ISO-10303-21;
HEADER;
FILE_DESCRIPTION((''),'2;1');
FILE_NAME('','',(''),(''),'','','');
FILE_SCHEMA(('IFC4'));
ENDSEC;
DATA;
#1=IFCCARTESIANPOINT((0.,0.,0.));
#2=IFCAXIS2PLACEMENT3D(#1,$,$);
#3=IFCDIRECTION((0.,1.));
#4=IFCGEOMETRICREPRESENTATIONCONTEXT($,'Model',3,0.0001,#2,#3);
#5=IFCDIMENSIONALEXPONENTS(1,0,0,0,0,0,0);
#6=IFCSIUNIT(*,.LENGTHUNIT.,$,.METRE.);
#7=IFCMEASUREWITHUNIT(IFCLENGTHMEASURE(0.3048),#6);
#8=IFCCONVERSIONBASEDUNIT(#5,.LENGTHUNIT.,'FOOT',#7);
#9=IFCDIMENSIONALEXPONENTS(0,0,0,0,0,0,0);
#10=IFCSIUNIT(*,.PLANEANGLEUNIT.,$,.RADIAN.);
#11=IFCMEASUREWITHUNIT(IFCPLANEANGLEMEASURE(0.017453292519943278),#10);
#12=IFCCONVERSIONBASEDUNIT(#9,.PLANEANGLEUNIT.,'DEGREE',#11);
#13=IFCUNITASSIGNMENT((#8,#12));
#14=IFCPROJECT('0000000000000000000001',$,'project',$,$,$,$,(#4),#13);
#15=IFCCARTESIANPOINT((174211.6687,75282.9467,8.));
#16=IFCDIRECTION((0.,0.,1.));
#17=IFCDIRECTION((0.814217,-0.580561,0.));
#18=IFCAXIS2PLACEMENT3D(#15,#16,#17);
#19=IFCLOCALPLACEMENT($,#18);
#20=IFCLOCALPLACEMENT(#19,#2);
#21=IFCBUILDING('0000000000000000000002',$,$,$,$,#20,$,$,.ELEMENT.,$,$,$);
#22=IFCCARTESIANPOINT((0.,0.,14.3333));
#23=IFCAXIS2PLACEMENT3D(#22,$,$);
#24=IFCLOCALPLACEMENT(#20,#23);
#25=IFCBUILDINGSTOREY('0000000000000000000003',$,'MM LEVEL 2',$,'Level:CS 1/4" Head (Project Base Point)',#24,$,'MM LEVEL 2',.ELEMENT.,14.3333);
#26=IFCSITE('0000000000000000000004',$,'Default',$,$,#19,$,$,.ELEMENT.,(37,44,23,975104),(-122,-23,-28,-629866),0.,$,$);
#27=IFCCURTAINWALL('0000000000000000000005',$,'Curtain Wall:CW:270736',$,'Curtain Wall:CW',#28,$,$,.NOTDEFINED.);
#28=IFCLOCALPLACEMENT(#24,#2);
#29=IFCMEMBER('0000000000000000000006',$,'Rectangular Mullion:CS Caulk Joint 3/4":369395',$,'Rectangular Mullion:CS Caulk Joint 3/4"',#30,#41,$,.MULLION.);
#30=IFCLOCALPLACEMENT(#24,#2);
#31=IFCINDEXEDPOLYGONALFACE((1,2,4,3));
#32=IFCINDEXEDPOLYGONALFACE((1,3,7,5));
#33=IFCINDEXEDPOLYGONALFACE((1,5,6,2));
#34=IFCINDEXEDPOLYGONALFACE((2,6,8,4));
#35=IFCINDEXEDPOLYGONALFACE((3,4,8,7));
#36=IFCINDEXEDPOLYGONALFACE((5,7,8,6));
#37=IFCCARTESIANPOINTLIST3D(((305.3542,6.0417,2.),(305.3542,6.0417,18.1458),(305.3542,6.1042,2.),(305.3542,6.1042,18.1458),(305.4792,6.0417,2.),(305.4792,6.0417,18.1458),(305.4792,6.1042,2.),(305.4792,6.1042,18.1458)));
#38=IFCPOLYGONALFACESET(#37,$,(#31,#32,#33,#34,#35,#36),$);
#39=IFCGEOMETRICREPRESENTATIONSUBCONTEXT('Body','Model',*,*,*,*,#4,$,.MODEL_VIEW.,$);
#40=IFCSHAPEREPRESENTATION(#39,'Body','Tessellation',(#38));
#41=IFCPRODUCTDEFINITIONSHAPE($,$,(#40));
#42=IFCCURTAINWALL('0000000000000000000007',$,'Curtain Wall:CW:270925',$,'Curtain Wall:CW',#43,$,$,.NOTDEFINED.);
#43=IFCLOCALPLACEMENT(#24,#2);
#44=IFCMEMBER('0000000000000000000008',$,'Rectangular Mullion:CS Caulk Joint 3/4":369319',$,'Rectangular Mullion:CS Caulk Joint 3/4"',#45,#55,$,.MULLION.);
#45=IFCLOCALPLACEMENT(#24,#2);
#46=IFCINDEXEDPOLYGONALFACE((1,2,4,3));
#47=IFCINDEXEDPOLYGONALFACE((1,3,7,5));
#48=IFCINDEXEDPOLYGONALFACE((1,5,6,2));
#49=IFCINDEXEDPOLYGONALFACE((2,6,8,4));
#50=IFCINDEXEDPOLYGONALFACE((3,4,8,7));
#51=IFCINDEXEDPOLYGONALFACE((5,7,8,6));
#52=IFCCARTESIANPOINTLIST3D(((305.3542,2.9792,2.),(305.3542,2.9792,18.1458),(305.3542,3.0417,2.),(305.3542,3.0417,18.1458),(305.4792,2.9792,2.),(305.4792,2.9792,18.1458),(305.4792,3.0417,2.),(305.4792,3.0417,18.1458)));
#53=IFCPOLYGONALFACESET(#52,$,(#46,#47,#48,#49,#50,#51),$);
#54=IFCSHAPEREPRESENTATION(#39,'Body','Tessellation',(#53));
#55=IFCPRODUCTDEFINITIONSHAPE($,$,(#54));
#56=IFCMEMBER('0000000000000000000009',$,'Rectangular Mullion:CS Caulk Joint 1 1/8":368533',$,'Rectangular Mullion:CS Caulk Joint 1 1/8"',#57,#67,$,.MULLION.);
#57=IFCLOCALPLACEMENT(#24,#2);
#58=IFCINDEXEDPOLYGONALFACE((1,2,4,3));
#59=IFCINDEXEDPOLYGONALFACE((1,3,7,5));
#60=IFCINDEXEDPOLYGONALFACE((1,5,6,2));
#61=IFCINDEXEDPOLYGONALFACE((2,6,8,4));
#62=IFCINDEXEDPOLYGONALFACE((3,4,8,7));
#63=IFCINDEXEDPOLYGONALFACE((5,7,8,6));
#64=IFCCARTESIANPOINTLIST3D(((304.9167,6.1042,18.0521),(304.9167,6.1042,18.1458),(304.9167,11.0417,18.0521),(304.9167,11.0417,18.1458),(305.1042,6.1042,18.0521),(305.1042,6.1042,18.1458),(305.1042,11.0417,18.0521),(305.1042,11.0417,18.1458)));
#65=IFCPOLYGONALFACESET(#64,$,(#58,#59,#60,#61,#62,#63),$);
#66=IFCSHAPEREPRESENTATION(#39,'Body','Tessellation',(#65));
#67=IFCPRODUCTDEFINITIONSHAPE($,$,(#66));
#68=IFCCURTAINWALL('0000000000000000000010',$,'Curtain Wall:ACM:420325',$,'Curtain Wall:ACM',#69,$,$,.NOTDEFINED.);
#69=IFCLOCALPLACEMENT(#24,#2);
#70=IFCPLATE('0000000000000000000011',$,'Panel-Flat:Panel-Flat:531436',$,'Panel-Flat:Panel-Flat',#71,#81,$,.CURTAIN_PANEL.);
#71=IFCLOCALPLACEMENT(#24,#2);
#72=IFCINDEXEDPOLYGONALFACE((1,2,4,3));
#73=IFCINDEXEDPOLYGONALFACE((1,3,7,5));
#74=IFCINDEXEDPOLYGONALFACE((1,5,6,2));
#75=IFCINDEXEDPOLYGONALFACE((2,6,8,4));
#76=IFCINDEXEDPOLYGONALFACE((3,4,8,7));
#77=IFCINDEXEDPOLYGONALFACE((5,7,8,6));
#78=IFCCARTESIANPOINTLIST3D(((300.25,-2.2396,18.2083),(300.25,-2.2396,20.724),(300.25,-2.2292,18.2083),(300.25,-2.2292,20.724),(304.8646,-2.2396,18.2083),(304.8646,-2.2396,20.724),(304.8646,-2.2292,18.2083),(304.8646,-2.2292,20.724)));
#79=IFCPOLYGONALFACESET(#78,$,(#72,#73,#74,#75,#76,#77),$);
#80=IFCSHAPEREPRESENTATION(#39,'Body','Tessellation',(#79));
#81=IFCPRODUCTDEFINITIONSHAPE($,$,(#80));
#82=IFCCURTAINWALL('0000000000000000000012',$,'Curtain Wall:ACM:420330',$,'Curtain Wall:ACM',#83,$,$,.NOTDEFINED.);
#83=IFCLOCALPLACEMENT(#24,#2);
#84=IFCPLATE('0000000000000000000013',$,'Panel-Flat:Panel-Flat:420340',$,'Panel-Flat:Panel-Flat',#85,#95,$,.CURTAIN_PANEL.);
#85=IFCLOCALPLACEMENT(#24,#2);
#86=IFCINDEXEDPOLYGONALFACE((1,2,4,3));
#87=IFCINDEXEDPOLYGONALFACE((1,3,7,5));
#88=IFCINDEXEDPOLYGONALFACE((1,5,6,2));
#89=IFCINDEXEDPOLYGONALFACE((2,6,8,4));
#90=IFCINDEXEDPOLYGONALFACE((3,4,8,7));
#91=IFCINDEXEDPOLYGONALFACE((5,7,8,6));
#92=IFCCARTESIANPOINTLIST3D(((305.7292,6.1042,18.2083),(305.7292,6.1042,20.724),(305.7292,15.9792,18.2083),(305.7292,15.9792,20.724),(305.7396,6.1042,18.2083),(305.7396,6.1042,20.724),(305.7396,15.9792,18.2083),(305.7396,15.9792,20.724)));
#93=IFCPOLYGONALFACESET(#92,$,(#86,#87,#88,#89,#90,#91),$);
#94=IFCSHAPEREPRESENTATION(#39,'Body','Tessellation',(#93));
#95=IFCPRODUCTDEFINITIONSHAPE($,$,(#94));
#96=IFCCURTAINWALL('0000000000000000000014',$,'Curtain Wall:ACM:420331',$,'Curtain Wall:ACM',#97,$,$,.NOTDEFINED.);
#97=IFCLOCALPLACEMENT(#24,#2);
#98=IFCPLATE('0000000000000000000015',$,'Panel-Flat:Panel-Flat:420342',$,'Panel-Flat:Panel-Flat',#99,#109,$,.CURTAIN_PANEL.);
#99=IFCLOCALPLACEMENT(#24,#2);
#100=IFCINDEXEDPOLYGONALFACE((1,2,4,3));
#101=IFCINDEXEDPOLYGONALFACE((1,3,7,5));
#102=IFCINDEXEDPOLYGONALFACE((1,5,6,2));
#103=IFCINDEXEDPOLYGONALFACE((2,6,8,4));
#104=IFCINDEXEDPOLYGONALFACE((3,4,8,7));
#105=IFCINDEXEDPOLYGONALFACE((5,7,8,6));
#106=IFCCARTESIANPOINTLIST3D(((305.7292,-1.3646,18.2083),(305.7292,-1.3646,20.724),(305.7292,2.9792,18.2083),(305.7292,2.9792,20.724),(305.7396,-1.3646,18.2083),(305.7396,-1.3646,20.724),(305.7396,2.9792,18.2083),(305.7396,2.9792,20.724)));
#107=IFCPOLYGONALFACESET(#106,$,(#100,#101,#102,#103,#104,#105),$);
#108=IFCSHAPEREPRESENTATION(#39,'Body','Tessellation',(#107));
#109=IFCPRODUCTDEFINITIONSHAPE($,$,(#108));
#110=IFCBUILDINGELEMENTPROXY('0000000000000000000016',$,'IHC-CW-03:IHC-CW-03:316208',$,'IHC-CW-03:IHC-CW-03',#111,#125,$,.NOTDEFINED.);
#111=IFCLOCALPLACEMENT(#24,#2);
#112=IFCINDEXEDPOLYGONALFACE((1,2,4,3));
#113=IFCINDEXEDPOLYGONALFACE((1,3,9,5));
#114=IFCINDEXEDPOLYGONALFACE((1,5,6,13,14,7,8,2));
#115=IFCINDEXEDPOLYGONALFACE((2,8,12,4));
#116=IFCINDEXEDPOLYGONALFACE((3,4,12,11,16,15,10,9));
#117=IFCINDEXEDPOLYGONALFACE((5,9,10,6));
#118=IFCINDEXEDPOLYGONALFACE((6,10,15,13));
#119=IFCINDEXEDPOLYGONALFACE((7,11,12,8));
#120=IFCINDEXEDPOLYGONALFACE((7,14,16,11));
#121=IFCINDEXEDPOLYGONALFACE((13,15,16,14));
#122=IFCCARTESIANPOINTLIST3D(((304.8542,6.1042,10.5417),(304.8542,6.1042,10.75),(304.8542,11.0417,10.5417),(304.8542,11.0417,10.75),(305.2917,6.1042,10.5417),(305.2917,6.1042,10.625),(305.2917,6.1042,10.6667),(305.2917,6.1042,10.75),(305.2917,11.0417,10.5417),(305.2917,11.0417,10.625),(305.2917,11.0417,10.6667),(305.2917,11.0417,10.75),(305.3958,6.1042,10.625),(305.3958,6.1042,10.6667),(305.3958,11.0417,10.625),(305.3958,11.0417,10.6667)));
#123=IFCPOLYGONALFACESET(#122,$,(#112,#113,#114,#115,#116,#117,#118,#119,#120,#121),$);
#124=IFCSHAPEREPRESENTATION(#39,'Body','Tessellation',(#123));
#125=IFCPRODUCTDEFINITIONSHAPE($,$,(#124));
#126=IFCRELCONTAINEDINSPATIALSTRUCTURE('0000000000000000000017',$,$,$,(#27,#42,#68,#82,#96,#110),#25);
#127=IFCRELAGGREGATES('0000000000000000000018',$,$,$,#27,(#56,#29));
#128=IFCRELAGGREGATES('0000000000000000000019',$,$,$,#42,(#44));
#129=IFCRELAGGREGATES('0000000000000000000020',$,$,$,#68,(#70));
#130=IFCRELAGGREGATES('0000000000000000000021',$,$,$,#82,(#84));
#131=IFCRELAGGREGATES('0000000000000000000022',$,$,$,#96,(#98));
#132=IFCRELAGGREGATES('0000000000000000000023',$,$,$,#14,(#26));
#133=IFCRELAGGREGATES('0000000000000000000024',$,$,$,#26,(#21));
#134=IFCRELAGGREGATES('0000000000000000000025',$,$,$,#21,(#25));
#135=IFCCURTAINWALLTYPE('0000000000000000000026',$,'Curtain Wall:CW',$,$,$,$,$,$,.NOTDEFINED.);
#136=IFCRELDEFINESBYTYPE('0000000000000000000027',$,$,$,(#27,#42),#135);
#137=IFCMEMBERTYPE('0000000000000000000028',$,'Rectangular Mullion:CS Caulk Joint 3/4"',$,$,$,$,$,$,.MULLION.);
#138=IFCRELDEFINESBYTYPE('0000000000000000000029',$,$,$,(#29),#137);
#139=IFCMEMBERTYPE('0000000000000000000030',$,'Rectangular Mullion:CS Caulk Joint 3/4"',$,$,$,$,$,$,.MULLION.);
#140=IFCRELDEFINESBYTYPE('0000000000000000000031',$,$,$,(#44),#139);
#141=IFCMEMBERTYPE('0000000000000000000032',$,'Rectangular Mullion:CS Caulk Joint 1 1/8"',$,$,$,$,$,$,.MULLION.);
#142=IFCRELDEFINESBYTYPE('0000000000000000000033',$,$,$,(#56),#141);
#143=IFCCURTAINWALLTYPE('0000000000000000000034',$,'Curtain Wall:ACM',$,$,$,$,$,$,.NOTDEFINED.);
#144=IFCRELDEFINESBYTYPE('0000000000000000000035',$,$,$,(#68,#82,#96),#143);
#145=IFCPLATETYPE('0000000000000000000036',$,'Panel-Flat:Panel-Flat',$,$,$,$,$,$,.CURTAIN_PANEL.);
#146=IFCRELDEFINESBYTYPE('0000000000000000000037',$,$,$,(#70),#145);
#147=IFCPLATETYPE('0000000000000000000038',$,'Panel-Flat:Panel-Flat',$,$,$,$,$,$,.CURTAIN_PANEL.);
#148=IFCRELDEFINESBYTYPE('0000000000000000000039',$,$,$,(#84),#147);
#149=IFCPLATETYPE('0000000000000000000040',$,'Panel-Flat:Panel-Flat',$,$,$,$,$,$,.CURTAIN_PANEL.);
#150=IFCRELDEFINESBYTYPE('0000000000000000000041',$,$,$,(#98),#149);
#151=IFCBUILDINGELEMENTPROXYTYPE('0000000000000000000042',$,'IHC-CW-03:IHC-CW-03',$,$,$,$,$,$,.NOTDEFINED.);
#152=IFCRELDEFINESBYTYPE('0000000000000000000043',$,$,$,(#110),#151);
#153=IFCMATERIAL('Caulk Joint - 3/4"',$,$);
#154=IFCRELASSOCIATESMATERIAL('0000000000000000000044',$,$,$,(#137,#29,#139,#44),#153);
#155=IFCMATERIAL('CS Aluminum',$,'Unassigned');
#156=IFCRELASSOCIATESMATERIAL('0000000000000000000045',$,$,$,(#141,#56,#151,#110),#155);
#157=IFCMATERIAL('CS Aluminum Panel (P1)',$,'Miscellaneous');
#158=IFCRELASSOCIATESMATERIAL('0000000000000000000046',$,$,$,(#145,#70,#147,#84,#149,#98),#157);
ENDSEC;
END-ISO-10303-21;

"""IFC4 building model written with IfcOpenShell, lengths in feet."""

from ifc_helpers import new_model, entity, si_unit, converted_unit, direction, frame, origin, place, context, subcontext, project, spatial, indexed_curve, outline, extrude, source, transform, mapped, material, type_object, type_shapes, element, aggregate, save


model = new_model("IFC4")

# Units and contexts
model_context = context("Model", 3, precision=0.0001, world=origin(), true_north=direction((0.0, 1.0)))
body_context = subcontext(model_context, "Body", "Model", "MODEL_VIEW")
ifc_project = project(units=[converted_unit("LENGTHUNIT", "FOOT", entity("IfcLengthMeasure", 0.3048), si_unit("LENGTHUNIT", "METRE"), dimensions=[1, 0, 0, 0, 0, 0, 0]), converted_unit("PLANEANGLEUNIT", "DEGREE", entity("IfcPlaneAngleMeasure", 0.017453292519943278), si_unit("PLANEANGLEUNIT", "RADIAN"), dimensions=[0, 0, 0, 0, 0, 0, 0])], contexts=[model_context])

# Site, building, storey
site_placement = place(None, frame((174211.6687, 75282.9467, 8.0), z_axis=(0.0, 0.0, 1.0), x_axis=(0.814217, -0.580561, 0.0)))
site = spatial("IfcSite", under=ifc_project, at=site_placement, Name="Default", CompositionType="ELEMENT", RefLatitude=(37, 44, 23, 975104), RefLongitude=(-122, -23, -28, -629866), RefElevation=0.0)
building_placement = place(site_placement, origin())
building = spatial("IfcBuilding", under=site, at=building_placement, CompositionType="ELEMENT")
storey_placement = place(building_placement, frame((0.0, 0.0, 14.3333)))
storey = spatial("IfcBuildingStorey", under=building, at=storey_placement, Name="MM LEVEL 2", ObjectType="Level:CS 1/4\" Head (Project Base Point)", LongName="MM LEVEL 2", CompositionType="ELEMENT", Elevation=14.3333)

# Curtain walls, members
curtain_wall_type_1 = type_object("IfcCurtainWallType", Name="Curtain Wall:CW", PredefinedType="NOTDEFINED")
curtain_wall_1_placement = place(storey_placement, frame((0.0, 0.0, -14.3333)))
curtain_wall_1 = element("IfcCurtainWall", 1, at=curtain_wall_1_placement, inside=storey, type_object=curtain_wall_type_1, Name="Curtain Wall:CW:270736", ObjectType="Curtain Wall:CW", PredefinedType="NOTDEFINED")
ifc_material_1 = material(Name="Caulk Joint - 3/4\"")
member_type_1 = type_object("IfcMemberType", Name="Rectangular Mullion:CS Caulk Joint 3/4\"", PredefinedType="MULLION", material=ifc_material_1)
shared_shape_1 = source(origin(), body_context, "Body", "SweptSolid", [
    extrude(outline(indexed_curve([(-0.0625, -0.0312), (0.0625, -0.0312), (0.0625, 0.0312), (-0.0625, 0.0312), (-0.0625, -0.0312)], self_intersect=False)), frame((-0.0312, 0.0625, -16.1458), z_axis=(0.0, 0.0, 1.0), x_axis=(0.0, -1.0, 0.0)), (0.0, 0.0, 1.0), 16.1458),
])
type_shapes(member_type_1, [shared_shape_1])
member_1_placement = place(curtain_wall_1_placement, frame((305.4792, 6.0417, 16.3333), z_axis=(0.0, 0.0, -1.0), x_axis=(0.0, -1.0, 0.0)))
member_1 = element("IfcMember", 2, at=member_1_placement, type_object=member_type_1, material=ifc_material_1, Name="Rectangular Mullion:CS Caulk Joint 3/4\":369395", ObjectType="Rectangular Mullion:CS Caulk Joint 3/4\"", PredefinedType="MULLION", context=body_context, shape_type="MappedRepresentation", body=[
    mapped(shared_shape_1, transform((0.0, 0.0, 0.0), scale=1.0)),
])
curtain_wall_2_placement = place(storey_placement, frame((0.0, 0.0, -14.3333)))
curtain_wall_2 = element("IfcCurtainWall", 3, at=curtain_wall_2_placement, inside=storey, type_object=curtain_wall_type_1, Name="Curtain Wall:CW:270925", ObjectType="Curtain Wall:CW", PredefinedType="NOTDEFINED")
member_type_2 = type_object("IfcMemberType", Name="Rectangular Mullion:CS Caulk Joint 3/4\"", PredefinedType="MULLION", material=ifc_material_1)
shared_shape_2 = source(origin(), body_context, "Body", "SweptSolid", [
    extrude(outline(indexed_curve([(-0.0312, -0.0625), (0.0312, -0.0625), (0.0312, 0.0625), (-0.0312, 0.0625), (-0.0312, -0.0625)], self_intersect=False)), frame((-0.0312, 0.0625, -16.1458), z_axis=(0.0, 0.0, 1.0), x_axis=(-1.0, 0.0, 0.0)), (0.0, 0.0, 1.0), 16.1458),
])
type_shapes(member_type_2, [shared_shape_2])
member_2_placement = place(curtain_wall_2_placement, frame((305.4792, 3.0417, 32.4792), z_axis=(0.0, 0.0, 1.0), x_axis=(0.0, 1.0, 0.0)))
member_2 = element("IfcMember", 4, at=member_2_placement, type_object=member_type_2, material=ifc_material_1, Name="Rectangular Mullion:CS Caulk Joint 3/4\":369319", ObjectType="Rectangular Mullion:CS Caulk Joint 3/4\"", PredefinedType="MULLION", context=body_context, shape_type="MappedRepresentation", body=[
    mapped(shared_shape_2, transform((0.0, 0.0, 0.0), scale=1.0)),
])

# Member
ifc_material_2 = material(Name="CS Aluminum", Category="Unassigned")
member_type_3 = type_object("IfcMemberType", Name="Rectangular Mullion:CS Caulk Joint 1 1/8\"", PredefinedType="MULLION", material=ifc_material_2)
shared_shape_3 = source(origin(), body_context, "Body", "SweptSolid", [
    extrude(outline(indexed_curve([(-0.0937, -0.0469), (0.0938, -0.0469), (0.0938, 0.0469), (-0.0937, 0.0469), (-0.0937, -0.0469)], self_intersect=False)), frame((-0.0469, 0.4688, -4.9375), z_axis=(0.0, 0.0, 1.0), x_axis=(0.0, -1.0, 0.0)), (0.0, 0.0, 1.0), 4.9375),
])
type_shapes(member_type_3, [shared_shape_3])
member_3_placement = place(curtain_wall_1_placement, frame((305.4792, 6.1042, 32.4792), z_axis=(0.0, -1.0, 0.0), x_axis=(0.0, 0.0, 1.0)))
member_3 = element("IfcMember", 5, at=member_3_placement, type_object=member_type_3, material=ifc_material_2, Name="Rectangular Mullion:CS Caulk Joint 1 1/8\":368533", ObjectType="Rectangular Mullion:CS Caulk Joint 1 1/8\"", PredefinedType="MULLION", context=body_context, shape_type="MappedRepresentation", body=[
    mapped(shared_shape_3, transform((0.0, 0.0, 0.0), scale=1.0)),
])
aggregate(curtain_wall_1, [member_3, member_1])
aggregate(curtain_wall_2, [member_2])

# Curtain walls, plates
curtain_wall_type_2 = type_object("IfcCurtainWallType", Name="Curtain Wall:ACM", PredefinedType="NOTDEFINED")
curtain_wall_3_placement = place(storey_placement, frame((0.0, 0.0, -14.3333)))
curtain_wall_3 = element("IfcCurtainWall", 6, at=curtain_wall_3_placement, inside=storey, type_object=curtain_wall_type_2, Name="Curtain Wall:ACM:420325", ObjectType="Curtain Wall:ACM", PredefinedType="NOTDEFINED")
ifc_material_3 = material(Name="CS Aluminum Panel (P1)", Category="Miscellaneous")
plate_type_1 = type_object("IfcPlateType", Name="Panel-Flat:Panel-Flat", PredefinedType="CURTAIN_PANEL", material=ifc_material_3)
shared_shape_4 = source(origin(), body_context, "Body", "SweptSolid", [
    extrude(outline(indexed_curve([(-0.0052, -2.3073), (0.0052, -2.3073), (0.0052, 2.3073), (-0.0052, 2.3073), (-0.0052, -2.3073)], self_intersect=False)), frame((-0.0208, -0.0052, 0.0), z_axis=(0.0, 0.0, 1.0), x_axis=(0.0, -1.0, 0.0)), (0.0, 0.0, 1.0), 2.5156),
])
type_shapes(plate_type_1, [shared_shape_4])
plate_1_placement = place(curtain_wall_3_placement, frame((302.5365, -2.2396, 32.5417), z_axis=(0.0, 0.0, 1.0), x_axis=(-1.0, 0.0, 0.0)))
plate_1 = element("IfcPlate", 7, at=plate_1_placement, type_object=plate_type_1, material=ifc_material_3, Name="Panel-Flat:Panel-Flat:531436", ObjectType="Panel-Flat:Panel-Flat", PredefinedType="CURTAIN_PANEL", context=body_context, shape_type="MappedRepresentation", body=[
    mapped(shared_shape_4, transform((0.0, 0.0, 0.0), scale=1.0)),
])
aggregate(curtain_wall_3, [plate_1])
curtain_wall_4_placement = place(storey_placement, frame((0.0, 0.0, -14.3333)))
curtain_wall_4 = element("IfcCurtainWall", 8, at=curtain_wall_4_placement, inside=storey, type_object=curtain_wall_type_2, Name="Curtain Wall:ACM:420330", ObjectType="Curtain Wall:ACM", PredefinedType="NOTDEFINED")
plate_type_2 = type_object("IfcPlateType", Name="Panel-Flat:Panel-Flat", PredefinedType="CURTAIN_PANEL", material=ifc_material_3)
shared_shape_5 = source(origin(), body_context, "Body", "SweptSolid", [
    extrude(outline(indexed_curve([(-0.0052, -4.9375), (0.0052, -4.9375), (0.0052, 4.9375), (-0.0052, 4.9375), (-0.0052, -4.9375)], self_intersect=False)), frame((0.0, -0.0052, 0.0), z_axis=(0.0, 0.0, 1.0), x_axis=(0.0, -1.0, 0.0)), (0.0, 0.0, 1.0), 2.5156),
])
type_shapes(plate_type_2, [shared_shape_5])
plate_2_placement = place(curtain_wall_4_placement, frame((305.7396, 11.0417, 32.5417), z_axis=(0.0, 0.0, 1.0), x_axis=(0.0, -1.0, 0.0)))
plate_2 = element("IfcPlate", 9, at=plate_2_placement, type_object=plate_type_2, material=ifc_material_3, Name="Panel-Flat:Panel-Flat:420340", ObjectType="Panel-Flat:Panel-Flat", PredefinedType="CURTAIN_PANEL", context=body_context, shape_type="MappedRepresentation", body=[
    mapped(shared_shape_5, transform((0.0, 0.0, 0.0), scale=1.0)),
])
aggregate(curtain_wall_4, [plate_2])

# Curtain wall, plate
curtain_wall_5_placement = place(storey_placement, frame((0.0, 0.0, -14.3333)))
curtain_wall_5 = element("IfcCurtainWall", 10, at=curtain_wall_5_placement, inside=storey, type_object=curtain_wall_type_2, Name="Curtain Wall:ACM:420331", ObjectType="Curtain Wall:ACM", PredefinedType="NOTDEFINED")
plate_type_3 = type_object("IfcPlateType", Name="Panel-Flat:Panel-Flat", PredefinedType="CURTAIN_PANEL", material=ifc_material_3)
shared_shape_6 = source(origin(), body_context, "Body", "SweptSolid", [
    extrude(outline(indexed_curve([(-0.0052, -2.1719), (0.0052, -2.1719), (0.0052, 2.1719), (-0.0052, 2.1719), (-0.0052, -2.1719)], self_intersect=False)), frame((0.0208, -0.0052, 0.0), z_axis=(0.0, 0.0, 1.0), x_axis=(0.0, -1.0, 0.0)), (0.0, 0.0, 1.0), 2.5156),
])
type_shapes(plate_type_3, [shared_shape_6])
plate_3_placement = place(curtain_wall_5_placement, frame((305.7396, 0.8281, 32.5417), z_axis=(0.0, 0.0, 1.0), x_axis=(0.0, -1.0, 0.0)))
plate_3 = element("IfcPlate", 11, at=plate_3_placement, type_object=plate_type_3, material=ifc_material_3, Name="Panel-Flat:Panel-Flat:420342", ObjectType="Panel-Flat:Panel-Flat", PredefinedType="CURTAIN_PANEL", context=body_context, shape_type="MappedRepresentation", body=[
    mapped(shared_shape_6, transform((0.0, 0.0, 0.0), scale=1.0)),
])
aggregate(curtain_wall_5, [plate_3])

# Building element proxy
building_element_proxy_type_1 = type_object("IfcBuildingElementProxyType", Name="IHC-CW-03:IHC-CW-03", PredefinedType="NOTDEFINED", material=ifc_material_2)
shared_shape_7 = source(origin(), body_context, "Body", "SweptSolid", [
    extrude(outline(indexed_curve([(-0.0208, -0.1875), (0.0208, -0.1875), (0.0208, -0.0833), (0.1042, -0.0833), (0.1042, 0.3542), (-0.1042, 0.3542), (-0.1042, -0.0833), (-0.0208, -0.0833), (-0.0208, -0.1875)], self_intersect=False)), frame((-2.4688, -0.2708, -0.1042), z_axis=(1.0, 0.0, 0.0), x_axis=(0.0, 0.0, 1.0)), (0.0, 0.0, 1.0), 4.9375),
])
type_shapes(building_element_proxy_type_1, [shared_shape_7])
proxy_1_placement = place(storey_placement, frame((305.4792, 8.5729, 10.75), z_axis=(0.0, 0.0, 1.0), x_axis=(0.0, -1.0, 0.0)))
element("IfcBuildingElementProxy", 12, at=proxy_1_placement, inside=storey, type_object=building_element_proxy_type_1, material=ifc_material_2, Name="IHC-CW-03:IHC-CW-03:316208", ObjectType="IHC-CW-03:IHC-CW-03", PredefinedType="NOTDEFINED", context=body_context, shape_type="MappedRepresentation", body=[
    mapped(shared_shape_7, transform((0.0, 0.0, 0.0), scale=1.0)),
])

save(model, "model.ifc")
